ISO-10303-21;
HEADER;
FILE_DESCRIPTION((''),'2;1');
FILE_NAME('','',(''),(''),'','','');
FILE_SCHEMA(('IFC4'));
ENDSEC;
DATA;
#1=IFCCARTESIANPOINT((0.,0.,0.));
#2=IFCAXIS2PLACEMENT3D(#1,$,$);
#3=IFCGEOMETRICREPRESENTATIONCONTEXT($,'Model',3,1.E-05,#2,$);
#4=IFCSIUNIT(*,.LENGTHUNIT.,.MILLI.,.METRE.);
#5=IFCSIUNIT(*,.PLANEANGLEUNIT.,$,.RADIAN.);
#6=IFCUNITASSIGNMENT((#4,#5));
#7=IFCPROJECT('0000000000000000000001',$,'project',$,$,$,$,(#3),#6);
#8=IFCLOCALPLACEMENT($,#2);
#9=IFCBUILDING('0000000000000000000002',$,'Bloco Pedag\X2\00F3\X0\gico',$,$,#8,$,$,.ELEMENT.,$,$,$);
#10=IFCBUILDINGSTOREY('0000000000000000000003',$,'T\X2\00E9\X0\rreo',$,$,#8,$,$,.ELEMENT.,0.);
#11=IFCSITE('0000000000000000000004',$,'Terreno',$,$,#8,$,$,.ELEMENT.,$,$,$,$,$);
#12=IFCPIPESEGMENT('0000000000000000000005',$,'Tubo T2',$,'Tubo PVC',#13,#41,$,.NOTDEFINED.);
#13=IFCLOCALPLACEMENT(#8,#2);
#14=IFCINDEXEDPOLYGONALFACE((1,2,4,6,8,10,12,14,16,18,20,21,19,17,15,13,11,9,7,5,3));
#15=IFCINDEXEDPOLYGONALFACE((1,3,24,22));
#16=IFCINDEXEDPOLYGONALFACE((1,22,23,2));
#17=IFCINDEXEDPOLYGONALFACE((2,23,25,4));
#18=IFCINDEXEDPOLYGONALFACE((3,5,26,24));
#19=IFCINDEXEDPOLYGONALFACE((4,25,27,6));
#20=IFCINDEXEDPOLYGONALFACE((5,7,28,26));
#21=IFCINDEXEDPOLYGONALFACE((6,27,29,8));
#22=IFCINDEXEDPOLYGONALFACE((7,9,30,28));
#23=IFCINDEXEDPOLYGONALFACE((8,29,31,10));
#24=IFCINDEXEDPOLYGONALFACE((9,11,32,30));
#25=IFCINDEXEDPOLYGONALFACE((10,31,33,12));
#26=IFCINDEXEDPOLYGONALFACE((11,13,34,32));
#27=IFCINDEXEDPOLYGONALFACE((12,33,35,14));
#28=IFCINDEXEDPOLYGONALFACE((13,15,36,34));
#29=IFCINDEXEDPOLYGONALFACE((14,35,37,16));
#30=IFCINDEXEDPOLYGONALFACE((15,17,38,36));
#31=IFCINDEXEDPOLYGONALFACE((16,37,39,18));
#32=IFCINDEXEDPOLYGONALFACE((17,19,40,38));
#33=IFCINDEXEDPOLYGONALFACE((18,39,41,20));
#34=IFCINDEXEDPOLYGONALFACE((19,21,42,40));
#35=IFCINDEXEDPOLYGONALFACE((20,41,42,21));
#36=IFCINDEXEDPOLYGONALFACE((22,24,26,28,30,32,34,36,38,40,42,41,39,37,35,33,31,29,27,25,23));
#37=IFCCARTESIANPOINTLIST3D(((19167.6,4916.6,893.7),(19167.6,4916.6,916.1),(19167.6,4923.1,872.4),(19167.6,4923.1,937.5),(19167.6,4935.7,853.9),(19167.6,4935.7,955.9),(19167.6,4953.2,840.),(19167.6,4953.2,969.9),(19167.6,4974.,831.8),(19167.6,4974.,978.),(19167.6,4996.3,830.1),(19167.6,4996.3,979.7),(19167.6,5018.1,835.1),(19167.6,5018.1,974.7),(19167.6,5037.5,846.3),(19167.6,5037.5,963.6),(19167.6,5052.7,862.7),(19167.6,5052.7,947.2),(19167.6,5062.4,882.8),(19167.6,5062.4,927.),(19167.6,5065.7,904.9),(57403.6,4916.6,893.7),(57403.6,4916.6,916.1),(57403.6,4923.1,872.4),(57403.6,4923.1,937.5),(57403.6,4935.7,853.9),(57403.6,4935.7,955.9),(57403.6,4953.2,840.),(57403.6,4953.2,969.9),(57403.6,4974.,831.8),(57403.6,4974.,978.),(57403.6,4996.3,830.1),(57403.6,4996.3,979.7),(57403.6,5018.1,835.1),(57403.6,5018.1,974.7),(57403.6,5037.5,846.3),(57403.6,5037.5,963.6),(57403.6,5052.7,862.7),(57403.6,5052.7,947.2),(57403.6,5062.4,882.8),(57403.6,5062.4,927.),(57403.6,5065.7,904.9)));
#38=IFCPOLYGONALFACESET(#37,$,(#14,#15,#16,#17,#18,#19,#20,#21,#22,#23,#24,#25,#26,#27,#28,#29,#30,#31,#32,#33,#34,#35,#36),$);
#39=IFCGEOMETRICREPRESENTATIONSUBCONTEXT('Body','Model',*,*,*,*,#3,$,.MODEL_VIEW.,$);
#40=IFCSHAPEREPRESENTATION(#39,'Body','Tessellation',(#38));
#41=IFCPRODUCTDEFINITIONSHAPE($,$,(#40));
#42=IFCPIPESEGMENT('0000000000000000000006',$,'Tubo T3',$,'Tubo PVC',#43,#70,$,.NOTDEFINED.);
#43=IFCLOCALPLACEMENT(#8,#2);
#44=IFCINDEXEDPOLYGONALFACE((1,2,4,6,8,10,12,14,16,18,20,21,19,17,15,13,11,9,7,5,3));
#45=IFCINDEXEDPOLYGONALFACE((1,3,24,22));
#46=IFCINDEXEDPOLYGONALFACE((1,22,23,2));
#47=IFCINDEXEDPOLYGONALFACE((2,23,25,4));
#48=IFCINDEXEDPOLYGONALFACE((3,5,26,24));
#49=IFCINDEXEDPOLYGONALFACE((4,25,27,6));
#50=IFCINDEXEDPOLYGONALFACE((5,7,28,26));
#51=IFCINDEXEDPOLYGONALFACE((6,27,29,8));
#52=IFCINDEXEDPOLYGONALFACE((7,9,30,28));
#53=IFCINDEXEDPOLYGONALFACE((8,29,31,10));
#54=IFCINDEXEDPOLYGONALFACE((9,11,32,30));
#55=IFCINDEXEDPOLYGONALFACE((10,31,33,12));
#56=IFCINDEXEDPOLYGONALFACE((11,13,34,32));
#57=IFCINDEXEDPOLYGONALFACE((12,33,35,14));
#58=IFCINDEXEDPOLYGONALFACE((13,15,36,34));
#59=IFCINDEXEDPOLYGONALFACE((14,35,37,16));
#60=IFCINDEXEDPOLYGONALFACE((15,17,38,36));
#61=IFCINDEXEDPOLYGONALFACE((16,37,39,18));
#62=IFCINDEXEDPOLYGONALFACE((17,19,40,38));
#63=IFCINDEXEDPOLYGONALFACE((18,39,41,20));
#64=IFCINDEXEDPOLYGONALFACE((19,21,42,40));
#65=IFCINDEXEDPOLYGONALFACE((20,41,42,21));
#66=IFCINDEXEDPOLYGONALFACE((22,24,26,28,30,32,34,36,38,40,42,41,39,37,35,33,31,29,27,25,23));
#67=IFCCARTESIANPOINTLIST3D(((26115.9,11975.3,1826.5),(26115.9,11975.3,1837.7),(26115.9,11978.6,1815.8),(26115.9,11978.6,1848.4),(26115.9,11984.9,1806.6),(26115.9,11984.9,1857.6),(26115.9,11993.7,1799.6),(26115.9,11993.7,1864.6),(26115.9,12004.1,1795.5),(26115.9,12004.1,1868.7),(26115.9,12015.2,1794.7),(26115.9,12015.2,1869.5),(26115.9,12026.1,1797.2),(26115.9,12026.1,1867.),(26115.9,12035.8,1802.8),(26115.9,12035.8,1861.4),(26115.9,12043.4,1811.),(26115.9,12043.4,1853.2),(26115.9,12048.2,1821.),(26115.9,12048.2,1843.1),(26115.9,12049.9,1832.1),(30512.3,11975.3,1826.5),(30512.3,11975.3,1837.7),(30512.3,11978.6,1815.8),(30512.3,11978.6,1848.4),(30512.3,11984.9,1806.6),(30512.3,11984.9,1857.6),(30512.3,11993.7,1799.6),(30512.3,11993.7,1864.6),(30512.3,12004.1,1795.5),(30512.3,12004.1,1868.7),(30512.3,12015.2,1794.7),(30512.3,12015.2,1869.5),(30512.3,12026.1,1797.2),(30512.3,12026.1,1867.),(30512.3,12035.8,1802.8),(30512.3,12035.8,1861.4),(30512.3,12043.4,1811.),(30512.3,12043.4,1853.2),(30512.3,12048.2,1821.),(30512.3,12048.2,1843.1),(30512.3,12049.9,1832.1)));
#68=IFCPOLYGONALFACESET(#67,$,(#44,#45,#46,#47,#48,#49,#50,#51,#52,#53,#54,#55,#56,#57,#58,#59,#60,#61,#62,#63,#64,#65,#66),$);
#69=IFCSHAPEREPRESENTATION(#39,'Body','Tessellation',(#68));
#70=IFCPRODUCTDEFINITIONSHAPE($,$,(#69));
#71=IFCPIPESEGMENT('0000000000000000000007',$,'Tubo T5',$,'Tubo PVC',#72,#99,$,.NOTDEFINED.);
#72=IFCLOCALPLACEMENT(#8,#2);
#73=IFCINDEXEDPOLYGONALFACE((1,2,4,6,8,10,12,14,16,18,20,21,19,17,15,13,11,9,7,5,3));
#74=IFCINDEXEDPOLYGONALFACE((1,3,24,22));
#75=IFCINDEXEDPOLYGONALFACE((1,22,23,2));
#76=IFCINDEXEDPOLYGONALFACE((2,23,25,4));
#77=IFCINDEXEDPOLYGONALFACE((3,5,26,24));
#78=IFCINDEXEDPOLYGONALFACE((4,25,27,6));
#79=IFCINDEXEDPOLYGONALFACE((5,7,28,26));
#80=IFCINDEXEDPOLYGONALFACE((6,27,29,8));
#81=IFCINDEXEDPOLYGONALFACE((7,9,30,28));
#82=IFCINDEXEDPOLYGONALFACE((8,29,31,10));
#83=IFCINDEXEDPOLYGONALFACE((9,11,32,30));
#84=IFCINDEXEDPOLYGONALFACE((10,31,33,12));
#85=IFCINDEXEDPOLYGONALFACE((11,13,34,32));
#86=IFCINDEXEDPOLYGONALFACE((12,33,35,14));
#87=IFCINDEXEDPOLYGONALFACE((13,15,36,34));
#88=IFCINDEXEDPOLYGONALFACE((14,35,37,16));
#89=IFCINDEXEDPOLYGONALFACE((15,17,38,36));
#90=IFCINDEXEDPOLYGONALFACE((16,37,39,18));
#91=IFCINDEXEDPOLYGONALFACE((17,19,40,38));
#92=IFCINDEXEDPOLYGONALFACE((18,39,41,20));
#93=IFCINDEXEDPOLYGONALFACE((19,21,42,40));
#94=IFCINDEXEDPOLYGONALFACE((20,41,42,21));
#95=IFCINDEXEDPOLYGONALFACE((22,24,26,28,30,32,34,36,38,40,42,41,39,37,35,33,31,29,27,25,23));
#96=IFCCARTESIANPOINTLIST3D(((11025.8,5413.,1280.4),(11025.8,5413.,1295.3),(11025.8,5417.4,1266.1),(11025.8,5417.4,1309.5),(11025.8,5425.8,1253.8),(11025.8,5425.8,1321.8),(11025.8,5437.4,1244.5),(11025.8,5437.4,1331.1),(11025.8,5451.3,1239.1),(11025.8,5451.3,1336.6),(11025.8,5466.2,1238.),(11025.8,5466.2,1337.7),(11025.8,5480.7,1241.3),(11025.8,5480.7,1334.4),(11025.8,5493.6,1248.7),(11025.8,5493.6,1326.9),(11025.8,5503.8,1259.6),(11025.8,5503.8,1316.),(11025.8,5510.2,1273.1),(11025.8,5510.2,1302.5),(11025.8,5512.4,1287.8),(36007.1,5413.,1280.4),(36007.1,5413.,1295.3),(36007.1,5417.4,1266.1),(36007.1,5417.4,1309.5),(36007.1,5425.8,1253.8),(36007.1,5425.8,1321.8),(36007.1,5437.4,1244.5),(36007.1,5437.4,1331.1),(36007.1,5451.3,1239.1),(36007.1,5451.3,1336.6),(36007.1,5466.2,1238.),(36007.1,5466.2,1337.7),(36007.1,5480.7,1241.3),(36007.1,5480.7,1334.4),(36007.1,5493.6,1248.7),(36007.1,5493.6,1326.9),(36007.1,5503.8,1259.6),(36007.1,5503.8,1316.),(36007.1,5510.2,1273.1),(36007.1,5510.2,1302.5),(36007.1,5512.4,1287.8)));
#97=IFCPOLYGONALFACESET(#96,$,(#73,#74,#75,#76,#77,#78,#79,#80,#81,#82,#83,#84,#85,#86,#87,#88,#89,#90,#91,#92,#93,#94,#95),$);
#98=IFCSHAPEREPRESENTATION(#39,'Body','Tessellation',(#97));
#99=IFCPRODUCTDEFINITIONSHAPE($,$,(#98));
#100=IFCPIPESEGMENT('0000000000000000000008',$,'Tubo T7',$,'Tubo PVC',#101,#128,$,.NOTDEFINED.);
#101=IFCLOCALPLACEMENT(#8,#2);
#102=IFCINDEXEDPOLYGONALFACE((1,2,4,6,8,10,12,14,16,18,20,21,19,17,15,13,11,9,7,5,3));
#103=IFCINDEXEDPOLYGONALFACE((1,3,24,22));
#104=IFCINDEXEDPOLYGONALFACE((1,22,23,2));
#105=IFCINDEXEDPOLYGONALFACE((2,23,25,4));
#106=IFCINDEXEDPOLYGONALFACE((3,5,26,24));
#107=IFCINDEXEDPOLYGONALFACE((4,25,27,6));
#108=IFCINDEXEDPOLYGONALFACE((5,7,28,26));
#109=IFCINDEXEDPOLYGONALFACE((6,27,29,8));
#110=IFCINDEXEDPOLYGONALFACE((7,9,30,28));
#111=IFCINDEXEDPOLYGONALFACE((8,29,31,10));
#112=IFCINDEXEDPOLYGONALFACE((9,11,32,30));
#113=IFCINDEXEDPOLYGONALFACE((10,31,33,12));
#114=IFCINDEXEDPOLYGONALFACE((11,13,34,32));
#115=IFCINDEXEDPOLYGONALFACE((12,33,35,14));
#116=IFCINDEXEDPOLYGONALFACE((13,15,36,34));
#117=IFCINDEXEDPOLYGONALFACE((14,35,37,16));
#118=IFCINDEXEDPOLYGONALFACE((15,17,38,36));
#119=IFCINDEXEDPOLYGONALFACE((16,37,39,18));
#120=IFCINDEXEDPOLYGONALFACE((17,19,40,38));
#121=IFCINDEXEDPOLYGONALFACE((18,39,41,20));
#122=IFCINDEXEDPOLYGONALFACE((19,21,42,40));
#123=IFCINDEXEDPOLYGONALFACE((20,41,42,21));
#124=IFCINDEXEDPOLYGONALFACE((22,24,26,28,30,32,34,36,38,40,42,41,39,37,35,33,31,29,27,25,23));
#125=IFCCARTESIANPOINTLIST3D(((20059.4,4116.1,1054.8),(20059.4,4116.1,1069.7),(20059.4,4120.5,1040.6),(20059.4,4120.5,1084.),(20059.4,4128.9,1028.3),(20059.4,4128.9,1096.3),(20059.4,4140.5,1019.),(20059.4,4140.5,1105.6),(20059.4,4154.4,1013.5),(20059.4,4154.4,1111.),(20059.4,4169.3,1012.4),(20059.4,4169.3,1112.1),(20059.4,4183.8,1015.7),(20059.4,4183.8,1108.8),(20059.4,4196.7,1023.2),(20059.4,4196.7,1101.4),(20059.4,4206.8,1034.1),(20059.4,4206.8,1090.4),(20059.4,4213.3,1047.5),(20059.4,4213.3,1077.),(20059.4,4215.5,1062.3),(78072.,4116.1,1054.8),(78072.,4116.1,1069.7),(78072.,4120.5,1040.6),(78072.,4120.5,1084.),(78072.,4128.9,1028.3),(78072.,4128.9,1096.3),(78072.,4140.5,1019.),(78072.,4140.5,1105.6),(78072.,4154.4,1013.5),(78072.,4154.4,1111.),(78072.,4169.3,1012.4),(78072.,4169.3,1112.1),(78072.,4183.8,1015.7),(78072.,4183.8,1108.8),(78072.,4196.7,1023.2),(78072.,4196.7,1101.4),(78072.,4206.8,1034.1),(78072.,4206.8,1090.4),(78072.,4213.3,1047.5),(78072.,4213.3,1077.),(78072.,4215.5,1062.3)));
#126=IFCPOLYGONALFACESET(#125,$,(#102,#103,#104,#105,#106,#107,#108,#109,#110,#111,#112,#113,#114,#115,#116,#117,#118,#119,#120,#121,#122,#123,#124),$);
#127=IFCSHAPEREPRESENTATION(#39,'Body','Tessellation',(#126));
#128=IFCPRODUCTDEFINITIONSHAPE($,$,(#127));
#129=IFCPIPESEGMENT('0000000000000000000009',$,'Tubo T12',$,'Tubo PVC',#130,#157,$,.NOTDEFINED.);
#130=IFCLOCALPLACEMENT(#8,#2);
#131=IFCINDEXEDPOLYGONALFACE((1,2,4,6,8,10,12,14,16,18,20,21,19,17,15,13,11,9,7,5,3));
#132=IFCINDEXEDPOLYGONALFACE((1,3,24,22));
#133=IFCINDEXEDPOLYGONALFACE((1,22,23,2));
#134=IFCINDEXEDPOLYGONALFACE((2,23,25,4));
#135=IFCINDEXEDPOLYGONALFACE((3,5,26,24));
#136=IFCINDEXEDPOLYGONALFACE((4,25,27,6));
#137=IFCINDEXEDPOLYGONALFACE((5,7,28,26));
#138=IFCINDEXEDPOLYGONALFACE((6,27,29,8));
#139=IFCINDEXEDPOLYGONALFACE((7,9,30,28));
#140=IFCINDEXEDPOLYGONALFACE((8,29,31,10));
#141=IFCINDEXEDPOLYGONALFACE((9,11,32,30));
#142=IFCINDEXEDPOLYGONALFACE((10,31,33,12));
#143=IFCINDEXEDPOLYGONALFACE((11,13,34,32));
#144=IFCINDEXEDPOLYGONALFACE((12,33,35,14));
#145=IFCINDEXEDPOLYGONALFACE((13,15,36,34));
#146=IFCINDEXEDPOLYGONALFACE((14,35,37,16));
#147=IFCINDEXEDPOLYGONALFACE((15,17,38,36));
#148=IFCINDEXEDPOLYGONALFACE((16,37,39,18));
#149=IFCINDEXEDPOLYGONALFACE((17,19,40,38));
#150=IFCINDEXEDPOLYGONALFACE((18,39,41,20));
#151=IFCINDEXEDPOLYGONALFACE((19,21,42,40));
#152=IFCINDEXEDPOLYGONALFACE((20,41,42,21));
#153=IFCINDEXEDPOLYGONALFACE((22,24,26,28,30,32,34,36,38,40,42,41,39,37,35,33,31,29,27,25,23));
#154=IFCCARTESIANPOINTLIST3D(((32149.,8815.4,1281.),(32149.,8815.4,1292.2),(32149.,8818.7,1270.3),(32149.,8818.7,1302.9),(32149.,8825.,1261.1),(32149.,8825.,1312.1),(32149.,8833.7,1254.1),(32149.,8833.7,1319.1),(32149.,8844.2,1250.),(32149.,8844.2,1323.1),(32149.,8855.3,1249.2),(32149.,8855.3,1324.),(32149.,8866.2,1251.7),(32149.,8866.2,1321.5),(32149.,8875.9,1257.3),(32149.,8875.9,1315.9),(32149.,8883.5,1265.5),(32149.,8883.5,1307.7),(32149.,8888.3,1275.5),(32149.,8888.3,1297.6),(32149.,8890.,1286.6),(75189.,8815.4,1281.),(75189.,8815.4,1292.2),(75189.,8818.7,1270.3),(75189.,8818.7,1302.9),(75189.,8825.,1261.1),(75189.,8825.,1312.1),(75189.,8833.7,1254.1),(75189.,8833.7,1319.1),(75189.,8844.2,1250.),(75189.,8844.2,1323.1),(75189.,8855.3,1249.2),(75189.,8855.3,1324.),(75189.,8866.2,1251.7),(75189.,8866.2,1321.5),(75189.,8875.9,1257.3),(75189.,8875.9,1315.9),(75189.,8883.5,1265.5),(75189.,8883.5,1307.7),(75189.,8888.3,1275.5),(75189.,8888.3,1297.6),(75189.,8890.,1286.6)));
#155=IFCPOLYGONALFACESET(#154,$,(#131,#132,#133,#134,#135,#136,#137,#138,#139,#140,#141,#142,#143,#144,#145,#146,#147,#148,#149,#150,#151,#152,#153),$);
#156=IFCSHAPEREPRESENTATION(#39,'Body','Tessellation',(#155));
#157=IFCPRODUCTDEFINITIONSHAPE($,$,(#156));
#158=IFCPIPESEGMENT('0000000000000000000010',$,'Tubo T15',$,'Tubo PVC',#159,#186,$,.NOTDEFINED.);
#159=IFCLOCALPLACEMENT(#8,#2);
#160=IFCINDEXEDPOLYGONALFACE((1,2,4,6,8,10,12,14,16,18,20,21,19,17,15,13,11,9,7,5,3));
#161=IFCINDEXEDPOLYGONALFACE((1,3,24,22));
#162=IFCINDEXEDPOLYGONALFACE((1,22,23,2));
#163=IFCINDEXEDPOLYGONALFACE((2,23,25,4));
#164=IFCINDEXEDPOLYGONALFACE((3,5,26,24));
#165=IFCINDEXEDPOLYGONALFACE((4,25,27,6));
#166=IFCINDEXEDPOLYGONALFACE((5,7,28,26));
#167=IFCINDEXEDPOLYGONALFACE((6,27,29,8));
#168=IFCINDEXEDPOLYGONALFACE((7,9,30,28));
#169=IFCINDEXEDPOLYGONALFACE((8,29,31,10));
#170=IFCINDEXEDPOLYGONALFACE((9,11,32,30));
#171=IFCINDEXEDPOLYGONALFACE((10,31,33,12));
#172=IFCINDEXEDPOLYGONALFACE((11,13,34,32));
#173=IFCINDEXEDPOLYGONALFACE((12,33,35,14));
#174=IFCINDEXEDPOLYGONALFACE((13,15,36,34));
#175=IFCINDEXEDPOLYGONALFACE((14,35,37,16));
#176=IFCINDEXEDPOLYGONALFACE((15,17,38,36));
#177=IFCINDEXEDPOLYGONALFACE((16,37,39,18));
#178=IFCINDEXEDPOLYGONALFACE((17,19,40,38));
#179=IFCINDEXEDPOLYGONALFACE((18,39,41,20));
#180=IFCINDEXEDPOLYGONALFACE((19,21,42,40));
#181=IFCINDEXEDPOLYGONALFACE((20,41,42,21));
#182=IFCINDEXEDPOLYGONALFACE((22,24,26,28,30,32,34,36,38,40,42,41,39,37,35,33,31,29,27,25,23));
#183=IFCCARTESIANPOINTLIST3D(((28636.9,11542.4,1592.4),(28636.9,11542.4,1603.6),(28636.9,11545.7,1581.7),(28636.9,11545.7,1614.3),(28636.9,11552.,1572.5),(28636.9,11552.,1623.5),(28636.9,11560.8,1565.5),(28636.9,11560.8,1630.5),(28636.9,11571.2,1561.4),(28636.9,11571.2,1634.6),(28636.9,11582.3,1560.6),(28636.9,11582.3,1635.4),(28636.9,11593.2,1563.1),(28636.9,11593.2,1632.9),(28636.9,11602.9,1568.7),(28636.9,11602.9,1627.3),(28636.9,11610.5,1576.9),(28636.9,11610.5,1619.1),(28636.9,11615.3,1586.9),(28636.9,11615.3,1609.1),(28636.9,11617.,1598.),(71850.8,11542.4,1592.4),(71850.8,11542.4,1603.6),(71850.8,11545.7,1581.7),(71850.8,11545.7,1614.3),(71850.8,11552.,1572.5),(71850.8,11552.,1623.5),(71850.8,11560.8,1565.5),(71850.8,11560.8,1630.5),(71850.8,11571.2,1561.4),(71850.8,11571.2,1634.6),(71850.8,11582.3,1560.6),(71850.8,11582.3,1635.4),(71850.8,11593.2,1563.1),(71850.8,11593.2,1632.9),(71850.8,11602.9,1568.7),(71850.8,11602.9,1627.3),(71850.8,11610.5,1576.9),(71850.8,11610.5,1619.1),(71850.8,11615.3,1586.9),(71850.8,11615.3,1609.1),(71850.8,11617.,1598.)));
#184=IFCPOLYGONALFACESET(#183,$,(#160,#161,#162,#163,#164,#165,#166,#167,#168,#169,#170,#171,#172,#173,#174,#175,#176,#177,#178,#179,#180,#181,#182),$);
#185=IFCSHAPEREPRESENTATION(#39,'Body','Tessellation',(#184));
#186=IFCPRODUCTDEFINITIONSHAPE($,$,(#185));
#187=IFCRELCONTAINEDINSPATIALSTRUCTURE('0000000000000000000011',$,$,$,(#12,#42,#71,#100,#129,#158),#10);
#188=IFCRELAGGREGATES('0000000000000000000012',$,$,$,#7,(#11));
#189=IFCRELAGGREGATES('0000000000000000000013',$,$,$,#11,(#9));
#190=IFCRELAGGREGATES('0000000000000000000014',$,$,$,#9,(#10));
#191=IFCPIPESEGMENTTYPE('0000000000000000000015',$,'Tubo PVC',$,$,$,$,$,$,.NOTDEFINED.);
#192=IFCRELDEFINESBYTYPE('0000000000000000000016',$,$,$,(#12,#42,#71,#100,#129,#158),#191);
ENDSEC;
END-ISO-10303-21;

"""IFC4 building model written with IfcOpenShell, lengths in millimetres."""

from ifc_helpers import new_model, si_unit, frame, origin, origin_2d, place, context, subcontext, project, spatial, circle, extrude, type_object, element, save


model = new_model("IFC4")

# Units and contexts
model_context = context("Model", 3, precision=1e-05, world=origin())
body_context = subcontext(model_context, "Body", "Model", "MODEL_VIEW")
ifc_project = project(units=[si_unit("LENGTHUNIT", "METRE", prefix="MILLI"), si_unit("PLANEANGLEUNIT", "RADIAN")], contexts=[model_context])

# Site, building, storey
placement = place(None, origin())
site = spatial("IfcSite", under=ifc_project, at=placement, Name="Terreno", CompositionType="ELEMENT")
building = spatial("IfcBuilding", under=site, at=placement, Name="Bloco Pedagógico", CompositionType="ELEMENT")
storey = spatial("IfcBuildingStorey", under=building, at=placement, Name="Térreo", CompositionType="ELEMENT", Elevation=0.0)

# Pipe segments
pipe_segment_type = type_object("IfcPipeSegmentType", Name="Tubo PVC", PredefinedType="NOTDEFINED")
pipe_segment_1_placement = place(None, frame((19167.6, 4990.7, 904.9), z_axis=(1.0, 0.0, 0.0), x_axis=(0.0, 1.0, 0.0)))
element("IfcPipeSegment", 1, at=pipe_segment_1_placement, inside=storey, type_object=pipe_segment_type, Name="Tubo T2", ObjectType="Tubo PVC", PredefinedType="NOTDEFINED", context=body_context, shape_type="SweptSolid", body=[
    extrude(circle(Radius=75.0, at=origin_2d()), None, (0.0, 0.0, 1.0), 38235.9),
])
pipe_segment_2_placement = place(None, frame((26115.9, 12012.4, 1832.1), z_axis=(1.0, 0.0, 0.0), x_axis=(0.0, 1.0, 0.0)))
element("IfcPipeSegment", 2, at=pipe_segment_2_placement, inside=storey, type_object=pipe_segment_type, Name="Tubo T3", ObjectType="Tubo PVC", PredefinedType="NOTDEFINED", context=body_context, shape_type="SweptSolid", body=[
    extrude(circle(Radius=37.5, at=origin_2d()), None, (0.0, 0.0, 1.0), 4396.4),
])
pipe_segment_3_placement = place(None, frame((11025.8, 5462.4, 1287.8), z_axis=(1.0, 0.0, 0.0), x_axis=(0.0, 1.0, 0.0)))
element("IfcPipeSegment", 3, at=pipe_segment_3_placement, inside=storey, type_object=pipe_segment_type, Name="Tubo T5", ObjectType="Tubo PVC", PredefinedType="NOTDEFINED", context=body_context, shape_type="SweptSolid", body=[
    extrude(circle(Radius=50.0, at=origin_2d()), None, (0.0, 0.0, 1.0), 24981.3),
])
pipe_segment_4_placement = place(None, frame((20059.4, 4165.5, 1062.3), z_axis=(1.0, 0.0, 0.0), x_axis=(0.0, 1.0, 0.0)))
element("IfcPipeSegment", 4, at=pipe_segment_4_placement, inside=storey, type_object=pipe_segment_type, Name="Tubo T7", ObjectType="Tubo PVC", PredefinedType="NOTDEFINED", context=body_context, shape_type="SweptSolid", body=[
    extrude(circle(Radius=50.0, at=origin_2d()), None, (0.0, 0.0, 1.0), 58012.6),
])
pipe_segment_5_placement = place(None, frame((32149.0, 8852.5, 1286.6), z_axis=(1.0, 0.0, 0.0), x_axis=(0.0, 1.0, 0.0)))
element("IfcPipeSegment", 5, at=pipe_segment_5_placement, inside=storey, type_object=pipe_segment_type, Name="Tubo T12", ObjectType="Tubo PVC", PredefinedType="NOTDEFINED", context=body_context, shape_type="SweptSolid", body=[
    extrude(circle(Radius=37.5, at=origin_2d()), None, (0.0, 0.0, 1.0), 43040.0),
])
pipe_segment_6_placement = place(None, frame((28636.9, 11579.5, 1598.0), z_axis=(1.0, 0.0, 0.0), x_axis=(0.0, 1.0, 0.0)))
element("IfcPipeSegment", 6, at=pipe_segment_6_placement, inside=storey, type_object=pipe_segment_type, Name="Tubo T15", ObjectType="Tubo PVC", PredefinedType="NOTDEFINED", context=body_context, shape_type="SweptSolid", body=[
    extrude(circle(Radius=37.5, at=origin_2d()), None, (0.0, 0.0, 1.0), 43214.0),
])

save(model, "model.ifc")
